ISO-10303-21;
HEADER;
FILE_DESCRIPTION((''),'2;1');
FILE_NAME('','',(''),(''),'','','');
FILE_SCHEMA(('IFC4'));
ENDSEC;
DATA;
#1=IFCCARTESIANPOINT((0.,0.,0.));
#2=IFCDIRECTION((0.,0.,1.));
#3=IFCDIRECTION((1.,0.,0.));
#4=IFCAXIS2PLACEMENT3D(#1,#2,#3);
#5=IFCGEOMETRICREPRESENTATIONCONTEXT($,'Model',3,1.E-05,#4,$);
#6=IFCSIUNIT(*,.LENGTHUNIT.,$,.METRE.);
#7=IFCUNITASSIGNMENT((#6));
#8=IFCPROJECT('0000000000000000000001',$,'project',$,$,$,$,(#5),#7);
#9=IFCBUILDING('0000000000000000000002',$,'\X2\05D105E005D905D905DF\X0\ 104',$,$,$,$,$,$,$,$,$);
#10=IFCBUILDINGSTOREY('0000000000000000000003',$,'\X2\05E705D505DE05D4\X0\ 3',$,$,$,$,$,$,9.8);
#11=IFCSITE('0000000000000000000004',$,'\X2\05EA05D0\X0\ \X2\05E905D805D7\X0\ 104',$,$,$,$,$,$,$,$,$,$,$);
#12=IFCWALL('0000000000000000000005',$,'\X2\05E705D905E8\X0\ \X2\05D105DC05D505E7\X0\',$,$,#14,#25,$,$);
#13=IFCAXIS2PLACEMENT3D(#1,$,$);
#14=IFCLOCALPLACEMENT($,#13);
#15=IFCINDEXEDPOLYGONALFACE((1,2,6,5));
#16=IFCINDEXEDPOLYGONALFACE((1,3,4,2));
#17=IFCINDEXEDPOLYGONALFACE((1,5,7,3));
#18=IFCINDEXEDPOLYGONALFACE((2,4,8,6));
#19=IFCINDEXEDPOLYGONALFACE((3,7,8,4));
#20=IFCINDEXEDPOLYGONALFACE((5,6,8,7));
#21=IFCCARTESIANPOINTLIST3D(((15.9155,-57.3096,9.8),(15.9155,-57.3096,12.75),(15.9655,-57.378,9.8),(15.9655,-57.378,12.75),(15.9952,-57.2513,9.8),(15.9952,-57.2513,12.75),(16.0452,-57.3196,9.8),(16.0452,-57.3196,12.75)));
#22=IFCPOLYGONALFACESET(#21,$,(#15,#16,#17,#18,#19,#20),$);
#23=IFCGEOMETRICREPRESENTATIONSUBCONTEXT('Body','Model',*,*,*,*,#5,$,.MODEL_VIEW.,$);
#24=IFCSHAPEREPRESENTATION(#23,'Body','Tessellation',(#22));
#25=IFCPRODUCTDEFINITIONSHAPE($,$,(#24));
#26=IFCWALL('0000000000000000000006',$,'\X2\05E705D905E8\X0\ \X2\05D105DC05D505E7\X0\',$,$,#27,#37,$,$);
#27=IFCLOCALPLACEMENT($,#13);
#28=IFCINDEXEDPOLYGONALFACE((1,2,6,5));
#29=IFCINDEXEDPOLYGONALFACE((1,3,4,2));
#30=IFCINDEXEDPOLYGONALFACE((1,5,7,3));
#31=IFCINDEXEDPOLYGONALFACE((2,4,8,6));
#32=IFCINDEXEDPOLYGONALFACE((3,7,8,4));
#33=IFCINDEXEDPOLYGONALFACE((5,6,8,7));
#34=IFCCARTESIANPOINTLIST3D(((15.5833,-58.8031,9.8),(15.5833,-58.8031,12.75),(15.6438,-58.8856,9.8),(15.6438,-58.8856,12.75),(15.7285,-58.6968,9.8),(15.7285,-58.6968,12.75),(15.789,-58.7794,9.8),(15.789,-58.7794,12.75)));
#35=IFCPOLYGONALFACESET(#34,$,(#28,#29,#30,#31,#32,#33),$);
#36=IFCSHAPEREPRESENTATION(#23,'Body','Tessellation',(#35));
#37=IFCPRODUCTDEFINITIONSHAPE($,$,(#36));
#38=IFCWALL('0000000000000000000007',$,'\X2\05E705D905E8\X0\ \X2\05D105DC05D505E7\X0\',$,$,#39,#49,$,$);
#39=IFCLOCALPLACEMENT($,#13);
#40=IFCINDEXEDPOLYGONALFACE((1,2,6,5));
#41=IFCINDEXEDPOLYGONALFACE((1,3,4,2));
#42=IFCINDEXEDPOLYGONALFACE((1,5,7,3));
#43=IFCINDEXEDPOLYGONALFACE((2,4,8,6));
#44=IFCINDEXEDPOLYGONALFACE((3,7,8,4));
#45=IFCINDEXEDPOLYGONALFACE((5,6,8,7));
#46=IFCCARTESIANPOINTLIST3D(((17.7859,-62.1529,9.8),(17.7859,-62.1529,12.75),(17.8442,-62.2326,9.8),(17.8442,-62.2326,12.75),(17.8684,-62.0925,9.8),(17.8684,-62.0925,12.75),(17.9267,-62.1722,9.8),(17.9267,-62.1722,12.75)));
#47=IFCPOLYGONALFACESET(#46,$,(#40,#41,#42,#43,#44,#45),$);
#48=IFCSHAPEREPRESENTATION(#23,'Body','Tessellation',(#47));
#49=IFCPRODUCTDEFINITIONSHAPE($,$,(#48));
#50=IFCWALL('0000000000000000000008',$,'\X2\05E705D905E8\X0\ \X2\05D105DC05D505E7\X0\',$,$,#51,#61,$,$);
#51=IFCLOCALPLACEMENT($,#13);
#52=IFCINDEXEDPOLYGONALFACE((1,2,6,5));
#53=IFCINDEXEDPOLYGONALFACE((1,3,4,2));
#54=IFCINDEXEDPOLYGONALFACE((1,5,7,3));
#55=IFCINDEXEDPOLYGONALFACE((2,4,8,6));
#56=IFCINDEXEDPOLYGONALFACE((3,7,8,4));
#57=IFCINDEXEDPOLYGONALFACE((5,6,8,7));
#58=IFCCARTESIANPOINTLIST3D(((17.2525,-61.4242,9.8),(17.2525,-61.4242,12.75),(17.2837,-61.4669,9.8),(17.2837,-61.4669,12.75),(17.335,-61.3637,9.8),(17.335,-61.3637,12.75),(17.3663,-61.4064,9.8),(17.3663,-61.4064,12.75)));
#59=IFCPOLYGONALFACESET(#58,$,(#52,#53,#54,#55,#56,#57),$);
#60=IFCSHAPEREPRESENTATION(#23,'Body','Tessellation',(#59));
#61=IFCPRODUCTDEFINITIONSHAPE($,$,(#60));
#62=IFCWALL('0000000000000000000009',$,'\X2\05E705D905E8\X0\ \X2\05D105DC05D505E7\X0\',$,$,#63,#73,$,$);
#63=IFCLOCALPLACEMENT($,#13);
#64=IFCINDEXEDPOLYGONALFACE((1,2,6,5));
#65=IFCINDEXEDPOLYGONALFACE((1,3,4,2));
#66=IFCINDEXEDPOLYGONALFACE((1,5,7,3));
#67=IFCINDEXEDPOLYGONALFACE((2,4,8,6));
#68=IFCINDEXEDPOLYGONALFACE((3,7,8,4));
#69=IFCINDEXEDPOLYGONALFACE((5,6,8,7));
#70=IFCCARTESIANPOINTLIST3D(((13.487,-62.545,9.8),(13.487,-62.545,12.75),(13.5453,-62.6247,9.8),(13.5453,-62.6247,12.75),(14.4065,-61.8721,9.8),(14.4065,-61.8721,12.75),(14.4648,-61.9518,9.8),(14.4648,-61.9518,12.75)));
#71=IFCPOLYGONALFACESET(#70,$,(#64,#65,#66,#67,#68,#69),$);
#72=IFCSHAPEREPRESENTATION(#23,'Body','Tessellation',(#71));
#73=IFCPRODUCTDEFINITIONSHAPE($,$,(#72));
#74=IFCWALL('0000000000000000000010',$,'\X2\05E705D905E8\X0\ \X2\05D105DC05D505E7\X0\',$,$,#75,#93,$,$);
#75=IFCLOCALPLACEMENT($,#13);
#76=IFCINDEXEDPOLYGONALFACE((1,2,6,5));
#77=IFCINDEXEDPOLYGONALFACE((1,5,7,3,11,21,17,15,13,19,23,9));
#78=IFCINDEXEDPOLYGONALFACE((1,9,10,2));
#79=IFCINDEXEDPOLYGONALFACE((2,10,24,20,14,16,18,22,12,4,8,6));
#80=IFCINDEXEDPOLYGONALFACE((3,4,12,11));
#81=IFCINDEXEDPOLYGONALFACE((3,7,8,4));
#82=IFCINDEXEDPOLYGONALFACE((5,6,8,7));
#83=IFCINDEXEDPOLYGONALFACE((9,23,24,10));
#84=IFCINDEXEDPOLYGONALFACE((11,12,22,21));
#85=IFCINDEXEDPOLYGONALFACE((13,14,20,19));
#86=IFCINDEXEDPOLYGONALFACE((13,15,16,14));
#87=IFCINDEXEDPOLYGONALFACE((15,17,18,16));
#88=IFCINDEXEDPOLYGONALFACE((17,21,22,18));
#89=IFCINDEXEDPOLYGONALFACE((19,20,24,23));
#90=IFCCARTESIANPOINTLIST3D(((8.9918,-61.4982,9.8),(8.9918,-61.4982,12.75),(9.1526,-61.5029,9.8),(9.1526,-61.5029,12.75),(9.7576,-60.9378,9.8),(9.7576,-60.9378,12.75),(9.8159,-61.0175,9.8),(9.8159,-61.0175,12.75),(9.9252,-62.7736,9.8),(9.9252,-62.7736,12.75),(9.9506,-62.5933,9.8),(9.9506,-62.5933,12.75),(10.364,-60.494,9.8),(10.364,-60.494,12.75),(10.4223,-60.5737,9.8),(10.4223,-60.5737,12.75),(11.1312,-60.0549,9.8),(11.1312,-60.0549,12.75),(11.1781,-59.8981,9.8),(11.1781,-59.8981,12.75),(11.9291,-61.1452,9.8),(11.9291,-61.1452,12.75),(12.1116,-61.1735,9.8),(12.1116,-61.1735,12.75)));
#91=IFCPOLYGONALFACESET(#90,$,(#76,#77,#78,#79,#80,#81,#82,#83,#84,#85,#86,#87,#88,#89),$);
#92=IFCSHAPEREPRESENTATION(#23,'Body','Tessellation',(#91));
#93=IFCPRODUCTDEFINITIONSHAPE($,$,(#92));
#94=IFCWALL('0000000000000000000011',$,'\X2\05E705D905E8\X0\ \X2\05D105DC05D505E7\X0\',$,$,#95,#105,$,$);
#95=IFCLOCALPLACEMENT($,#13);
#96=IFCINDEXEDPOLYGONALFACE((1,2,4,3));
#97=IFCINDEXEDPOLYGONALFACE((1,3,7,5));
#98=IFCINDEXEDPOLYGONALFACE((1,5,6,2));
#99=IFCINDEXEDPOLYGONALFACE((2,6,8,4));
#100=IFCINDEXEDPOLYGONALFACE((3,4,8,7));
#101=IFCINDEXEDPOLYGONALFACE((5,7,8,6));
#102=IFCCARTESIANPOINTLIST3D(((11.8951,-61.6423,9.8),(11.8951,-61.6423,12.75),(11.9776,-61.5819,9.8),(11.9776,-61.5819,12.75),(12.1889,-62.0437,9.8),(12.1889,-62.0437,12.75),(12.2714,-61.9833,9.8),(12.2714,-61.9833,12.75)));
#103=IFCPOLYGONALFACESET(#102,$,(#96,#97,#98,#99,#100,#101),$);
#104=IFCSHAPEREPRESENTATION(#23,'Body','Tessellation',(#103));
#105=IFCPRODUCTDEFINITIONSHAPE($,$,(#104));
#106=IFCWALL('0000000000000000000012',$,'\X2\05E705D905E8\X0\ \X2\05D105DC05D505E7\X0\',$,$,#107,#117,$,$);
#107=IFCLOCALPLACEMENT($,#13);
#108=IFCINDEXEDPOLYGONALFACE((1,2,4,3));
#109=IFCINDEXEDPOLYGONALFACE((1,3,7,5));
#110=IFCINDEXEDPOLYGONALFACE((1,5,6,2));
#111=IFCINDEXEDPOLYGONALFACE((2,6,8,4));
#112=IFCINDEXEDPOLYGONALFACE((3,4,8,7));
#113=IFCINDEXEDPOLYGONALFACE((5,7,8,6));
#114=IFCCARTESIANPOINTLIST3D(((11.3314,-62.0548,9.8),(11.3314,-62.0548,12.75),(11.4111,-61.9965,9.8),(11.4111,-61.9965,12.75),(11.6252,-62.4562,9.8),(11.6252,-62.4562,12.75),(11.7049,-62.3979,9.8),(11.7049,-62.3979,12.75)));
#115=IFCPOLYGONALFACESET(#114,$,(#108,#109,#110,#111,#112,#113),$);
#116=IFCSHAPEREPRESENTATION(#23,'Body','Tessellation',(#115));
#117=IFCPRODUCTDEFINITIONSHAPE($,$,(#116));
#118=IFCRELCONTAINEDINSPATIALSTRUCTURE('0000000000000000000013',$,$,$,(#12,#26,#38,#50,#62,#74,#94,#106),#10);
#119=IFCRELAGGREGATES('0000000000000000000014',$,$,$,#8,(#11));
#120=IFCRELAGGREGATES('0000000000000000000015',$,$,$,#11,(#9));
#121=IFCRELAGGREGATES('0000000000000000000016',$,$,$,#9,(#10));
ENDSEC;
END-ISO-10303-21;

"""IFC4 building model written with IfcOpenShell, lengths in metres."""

from ifc_helpers import new_model, si_unit, frame, origin_with_axes, context, subcontext, project, spatial, polyline, outline, extrude, element, save


model = new_model("IFC4")

# Units and contexts
model_context = context("Model", 3, precision=1e-05, world=origin_with_axes())
body_context = subcontext(model_context, "Body", "Model", "MODEL_VIEW")
ifc_project = project(units=[si_unit("LENGTHUNIT", "METRE")], contexts=[model_context])

# Site, building, storey
site = spatial("IfcSite", under=ifc_project, Name="תא שטח 104")
building = spatial("IfcBuilding", under=site, Name="בניין 104")
storey = spatial("IfcBuildingStorey", under=building, Name="קומה 3", Elevation=9.8)

# Walls
element("IfcWall", 1, inside=storey, Name="קיר בלוק", context=body_context, shape_type="SweptSolid", body=[
    extrude(outline(polyline([(15.9155, -57.3096), (15.9655, -57.378), (16.0452, -57.3196), (15.9952, -57.2513), (15.9155, -57.3096)])), frame((0.0, 0.0, 9.8)), (0.0, 0.0, 1.0), 2.95),
])
element("IfcWall", 2, inside=storey, Name="קיר בלוק", context=body_context, shape_type="SweptSolid", body=[
    extrude(outline(polyline([(15.6438, -58.8856), (15.789, -58.7794), (15.7285, -58.6968), (15.5833, -58.8031), (15.6438, -58.8856)])), frame((0.0, 0.0, 9.8)), (0.0, 0.0, 1.0), 2.95),
])
element("IfcWall", 3, inside=storey, Name="קיר בלוק", context=body_context, shape_type="SweptSolid", body=[
    extrude(outline(polyline([(17.9267, -62.1722), (17.8684, -62.0925), (17.7859, -62.1529), (17.8442, -62.2326), (17.9267, -62.1722)])), frame((0.0, 0.0, 9.8)), (0.0, 0.0, 1.0), 2.95),
])
element("IfcWall", 4, inside=storey, Name="קיר בלוק", context=body_context, shape_type="SweptSolid", body=[
    extrude(outline(polyline([(17.2525, -61.4242), (17.2837, -61.4669), (17.3663, -61.4064), (17.335, -61.3637), (17.2525, -61.4242)])), frame((0.0, 0.0, 9.8)), (0.0, 0.0, 1.0), 2.95),
])
element("IfcWall", 5, inside=storey, Name="קיר בלוק", context=body_context, shape_type="SweptSolid", body=[
    extrude(outline(polyline([(13.487, -62.545), (13.5453, -62.6247), (14.4648, -61.9518), (14.4065, -61.8721), (13.487, -62.545)])), frame((0.0, 0.0, 9.8)), (0.0, 0.0, 1.0), 2.95),
])
element("IfcWall", 6, inside=storey, Name="קיר בלוק", context=body_context, shape_type="SweptSolid", body=[
    extrude(outline(polyline([(9.1526, -61.5029), (9.8159, -61.0175), (9.7576, -60.9378), (8.9918, -61.4982), (9.9252, -62.7736), (12.1116, -61.1735), (11.1781, -59.8981), (10.364, -60.494), (10.4223, -60.5737), (11.1312, -60.0549), (11.9291, -61.1452), (9.9506, -62.5933), (9.1526, -61.5029)])), frame((0.0, 0.0, 9.8)), (0.0, 0.0, 1.0), 2.95),
])
element("IfcWall", 7, inside=storey, Name="קיר בלוק", context=body_context, shape_type="SweptSolid", body=[
    extrude(outline(polyline([(11.8951, -61.6423), (12.1889, -62.0437), (12.2714, -61.9833), (11.9776, -61.5819), (11.8951, -61.6423)])), frame((0.0, 0.0, 9.8)), (0.0, 0.0, 1.0), 2.95),
])
element("IfcWall", 8, inside=storey, Name="קיר בלוק", context=body_context, shape_type="SweptSolid", body=[
    extrude(outline(polyline([(11.3314, -62.0548), (11.6252, -62.4562), (11.7049, -62.3979), (11.4111, -61.9965), (11.3314, -62.0548)])), frame((0.0, 0.0, 9.8)), (0.0, 0.0, 1.0), 2.95),
])

save(model, "model.ifc")
